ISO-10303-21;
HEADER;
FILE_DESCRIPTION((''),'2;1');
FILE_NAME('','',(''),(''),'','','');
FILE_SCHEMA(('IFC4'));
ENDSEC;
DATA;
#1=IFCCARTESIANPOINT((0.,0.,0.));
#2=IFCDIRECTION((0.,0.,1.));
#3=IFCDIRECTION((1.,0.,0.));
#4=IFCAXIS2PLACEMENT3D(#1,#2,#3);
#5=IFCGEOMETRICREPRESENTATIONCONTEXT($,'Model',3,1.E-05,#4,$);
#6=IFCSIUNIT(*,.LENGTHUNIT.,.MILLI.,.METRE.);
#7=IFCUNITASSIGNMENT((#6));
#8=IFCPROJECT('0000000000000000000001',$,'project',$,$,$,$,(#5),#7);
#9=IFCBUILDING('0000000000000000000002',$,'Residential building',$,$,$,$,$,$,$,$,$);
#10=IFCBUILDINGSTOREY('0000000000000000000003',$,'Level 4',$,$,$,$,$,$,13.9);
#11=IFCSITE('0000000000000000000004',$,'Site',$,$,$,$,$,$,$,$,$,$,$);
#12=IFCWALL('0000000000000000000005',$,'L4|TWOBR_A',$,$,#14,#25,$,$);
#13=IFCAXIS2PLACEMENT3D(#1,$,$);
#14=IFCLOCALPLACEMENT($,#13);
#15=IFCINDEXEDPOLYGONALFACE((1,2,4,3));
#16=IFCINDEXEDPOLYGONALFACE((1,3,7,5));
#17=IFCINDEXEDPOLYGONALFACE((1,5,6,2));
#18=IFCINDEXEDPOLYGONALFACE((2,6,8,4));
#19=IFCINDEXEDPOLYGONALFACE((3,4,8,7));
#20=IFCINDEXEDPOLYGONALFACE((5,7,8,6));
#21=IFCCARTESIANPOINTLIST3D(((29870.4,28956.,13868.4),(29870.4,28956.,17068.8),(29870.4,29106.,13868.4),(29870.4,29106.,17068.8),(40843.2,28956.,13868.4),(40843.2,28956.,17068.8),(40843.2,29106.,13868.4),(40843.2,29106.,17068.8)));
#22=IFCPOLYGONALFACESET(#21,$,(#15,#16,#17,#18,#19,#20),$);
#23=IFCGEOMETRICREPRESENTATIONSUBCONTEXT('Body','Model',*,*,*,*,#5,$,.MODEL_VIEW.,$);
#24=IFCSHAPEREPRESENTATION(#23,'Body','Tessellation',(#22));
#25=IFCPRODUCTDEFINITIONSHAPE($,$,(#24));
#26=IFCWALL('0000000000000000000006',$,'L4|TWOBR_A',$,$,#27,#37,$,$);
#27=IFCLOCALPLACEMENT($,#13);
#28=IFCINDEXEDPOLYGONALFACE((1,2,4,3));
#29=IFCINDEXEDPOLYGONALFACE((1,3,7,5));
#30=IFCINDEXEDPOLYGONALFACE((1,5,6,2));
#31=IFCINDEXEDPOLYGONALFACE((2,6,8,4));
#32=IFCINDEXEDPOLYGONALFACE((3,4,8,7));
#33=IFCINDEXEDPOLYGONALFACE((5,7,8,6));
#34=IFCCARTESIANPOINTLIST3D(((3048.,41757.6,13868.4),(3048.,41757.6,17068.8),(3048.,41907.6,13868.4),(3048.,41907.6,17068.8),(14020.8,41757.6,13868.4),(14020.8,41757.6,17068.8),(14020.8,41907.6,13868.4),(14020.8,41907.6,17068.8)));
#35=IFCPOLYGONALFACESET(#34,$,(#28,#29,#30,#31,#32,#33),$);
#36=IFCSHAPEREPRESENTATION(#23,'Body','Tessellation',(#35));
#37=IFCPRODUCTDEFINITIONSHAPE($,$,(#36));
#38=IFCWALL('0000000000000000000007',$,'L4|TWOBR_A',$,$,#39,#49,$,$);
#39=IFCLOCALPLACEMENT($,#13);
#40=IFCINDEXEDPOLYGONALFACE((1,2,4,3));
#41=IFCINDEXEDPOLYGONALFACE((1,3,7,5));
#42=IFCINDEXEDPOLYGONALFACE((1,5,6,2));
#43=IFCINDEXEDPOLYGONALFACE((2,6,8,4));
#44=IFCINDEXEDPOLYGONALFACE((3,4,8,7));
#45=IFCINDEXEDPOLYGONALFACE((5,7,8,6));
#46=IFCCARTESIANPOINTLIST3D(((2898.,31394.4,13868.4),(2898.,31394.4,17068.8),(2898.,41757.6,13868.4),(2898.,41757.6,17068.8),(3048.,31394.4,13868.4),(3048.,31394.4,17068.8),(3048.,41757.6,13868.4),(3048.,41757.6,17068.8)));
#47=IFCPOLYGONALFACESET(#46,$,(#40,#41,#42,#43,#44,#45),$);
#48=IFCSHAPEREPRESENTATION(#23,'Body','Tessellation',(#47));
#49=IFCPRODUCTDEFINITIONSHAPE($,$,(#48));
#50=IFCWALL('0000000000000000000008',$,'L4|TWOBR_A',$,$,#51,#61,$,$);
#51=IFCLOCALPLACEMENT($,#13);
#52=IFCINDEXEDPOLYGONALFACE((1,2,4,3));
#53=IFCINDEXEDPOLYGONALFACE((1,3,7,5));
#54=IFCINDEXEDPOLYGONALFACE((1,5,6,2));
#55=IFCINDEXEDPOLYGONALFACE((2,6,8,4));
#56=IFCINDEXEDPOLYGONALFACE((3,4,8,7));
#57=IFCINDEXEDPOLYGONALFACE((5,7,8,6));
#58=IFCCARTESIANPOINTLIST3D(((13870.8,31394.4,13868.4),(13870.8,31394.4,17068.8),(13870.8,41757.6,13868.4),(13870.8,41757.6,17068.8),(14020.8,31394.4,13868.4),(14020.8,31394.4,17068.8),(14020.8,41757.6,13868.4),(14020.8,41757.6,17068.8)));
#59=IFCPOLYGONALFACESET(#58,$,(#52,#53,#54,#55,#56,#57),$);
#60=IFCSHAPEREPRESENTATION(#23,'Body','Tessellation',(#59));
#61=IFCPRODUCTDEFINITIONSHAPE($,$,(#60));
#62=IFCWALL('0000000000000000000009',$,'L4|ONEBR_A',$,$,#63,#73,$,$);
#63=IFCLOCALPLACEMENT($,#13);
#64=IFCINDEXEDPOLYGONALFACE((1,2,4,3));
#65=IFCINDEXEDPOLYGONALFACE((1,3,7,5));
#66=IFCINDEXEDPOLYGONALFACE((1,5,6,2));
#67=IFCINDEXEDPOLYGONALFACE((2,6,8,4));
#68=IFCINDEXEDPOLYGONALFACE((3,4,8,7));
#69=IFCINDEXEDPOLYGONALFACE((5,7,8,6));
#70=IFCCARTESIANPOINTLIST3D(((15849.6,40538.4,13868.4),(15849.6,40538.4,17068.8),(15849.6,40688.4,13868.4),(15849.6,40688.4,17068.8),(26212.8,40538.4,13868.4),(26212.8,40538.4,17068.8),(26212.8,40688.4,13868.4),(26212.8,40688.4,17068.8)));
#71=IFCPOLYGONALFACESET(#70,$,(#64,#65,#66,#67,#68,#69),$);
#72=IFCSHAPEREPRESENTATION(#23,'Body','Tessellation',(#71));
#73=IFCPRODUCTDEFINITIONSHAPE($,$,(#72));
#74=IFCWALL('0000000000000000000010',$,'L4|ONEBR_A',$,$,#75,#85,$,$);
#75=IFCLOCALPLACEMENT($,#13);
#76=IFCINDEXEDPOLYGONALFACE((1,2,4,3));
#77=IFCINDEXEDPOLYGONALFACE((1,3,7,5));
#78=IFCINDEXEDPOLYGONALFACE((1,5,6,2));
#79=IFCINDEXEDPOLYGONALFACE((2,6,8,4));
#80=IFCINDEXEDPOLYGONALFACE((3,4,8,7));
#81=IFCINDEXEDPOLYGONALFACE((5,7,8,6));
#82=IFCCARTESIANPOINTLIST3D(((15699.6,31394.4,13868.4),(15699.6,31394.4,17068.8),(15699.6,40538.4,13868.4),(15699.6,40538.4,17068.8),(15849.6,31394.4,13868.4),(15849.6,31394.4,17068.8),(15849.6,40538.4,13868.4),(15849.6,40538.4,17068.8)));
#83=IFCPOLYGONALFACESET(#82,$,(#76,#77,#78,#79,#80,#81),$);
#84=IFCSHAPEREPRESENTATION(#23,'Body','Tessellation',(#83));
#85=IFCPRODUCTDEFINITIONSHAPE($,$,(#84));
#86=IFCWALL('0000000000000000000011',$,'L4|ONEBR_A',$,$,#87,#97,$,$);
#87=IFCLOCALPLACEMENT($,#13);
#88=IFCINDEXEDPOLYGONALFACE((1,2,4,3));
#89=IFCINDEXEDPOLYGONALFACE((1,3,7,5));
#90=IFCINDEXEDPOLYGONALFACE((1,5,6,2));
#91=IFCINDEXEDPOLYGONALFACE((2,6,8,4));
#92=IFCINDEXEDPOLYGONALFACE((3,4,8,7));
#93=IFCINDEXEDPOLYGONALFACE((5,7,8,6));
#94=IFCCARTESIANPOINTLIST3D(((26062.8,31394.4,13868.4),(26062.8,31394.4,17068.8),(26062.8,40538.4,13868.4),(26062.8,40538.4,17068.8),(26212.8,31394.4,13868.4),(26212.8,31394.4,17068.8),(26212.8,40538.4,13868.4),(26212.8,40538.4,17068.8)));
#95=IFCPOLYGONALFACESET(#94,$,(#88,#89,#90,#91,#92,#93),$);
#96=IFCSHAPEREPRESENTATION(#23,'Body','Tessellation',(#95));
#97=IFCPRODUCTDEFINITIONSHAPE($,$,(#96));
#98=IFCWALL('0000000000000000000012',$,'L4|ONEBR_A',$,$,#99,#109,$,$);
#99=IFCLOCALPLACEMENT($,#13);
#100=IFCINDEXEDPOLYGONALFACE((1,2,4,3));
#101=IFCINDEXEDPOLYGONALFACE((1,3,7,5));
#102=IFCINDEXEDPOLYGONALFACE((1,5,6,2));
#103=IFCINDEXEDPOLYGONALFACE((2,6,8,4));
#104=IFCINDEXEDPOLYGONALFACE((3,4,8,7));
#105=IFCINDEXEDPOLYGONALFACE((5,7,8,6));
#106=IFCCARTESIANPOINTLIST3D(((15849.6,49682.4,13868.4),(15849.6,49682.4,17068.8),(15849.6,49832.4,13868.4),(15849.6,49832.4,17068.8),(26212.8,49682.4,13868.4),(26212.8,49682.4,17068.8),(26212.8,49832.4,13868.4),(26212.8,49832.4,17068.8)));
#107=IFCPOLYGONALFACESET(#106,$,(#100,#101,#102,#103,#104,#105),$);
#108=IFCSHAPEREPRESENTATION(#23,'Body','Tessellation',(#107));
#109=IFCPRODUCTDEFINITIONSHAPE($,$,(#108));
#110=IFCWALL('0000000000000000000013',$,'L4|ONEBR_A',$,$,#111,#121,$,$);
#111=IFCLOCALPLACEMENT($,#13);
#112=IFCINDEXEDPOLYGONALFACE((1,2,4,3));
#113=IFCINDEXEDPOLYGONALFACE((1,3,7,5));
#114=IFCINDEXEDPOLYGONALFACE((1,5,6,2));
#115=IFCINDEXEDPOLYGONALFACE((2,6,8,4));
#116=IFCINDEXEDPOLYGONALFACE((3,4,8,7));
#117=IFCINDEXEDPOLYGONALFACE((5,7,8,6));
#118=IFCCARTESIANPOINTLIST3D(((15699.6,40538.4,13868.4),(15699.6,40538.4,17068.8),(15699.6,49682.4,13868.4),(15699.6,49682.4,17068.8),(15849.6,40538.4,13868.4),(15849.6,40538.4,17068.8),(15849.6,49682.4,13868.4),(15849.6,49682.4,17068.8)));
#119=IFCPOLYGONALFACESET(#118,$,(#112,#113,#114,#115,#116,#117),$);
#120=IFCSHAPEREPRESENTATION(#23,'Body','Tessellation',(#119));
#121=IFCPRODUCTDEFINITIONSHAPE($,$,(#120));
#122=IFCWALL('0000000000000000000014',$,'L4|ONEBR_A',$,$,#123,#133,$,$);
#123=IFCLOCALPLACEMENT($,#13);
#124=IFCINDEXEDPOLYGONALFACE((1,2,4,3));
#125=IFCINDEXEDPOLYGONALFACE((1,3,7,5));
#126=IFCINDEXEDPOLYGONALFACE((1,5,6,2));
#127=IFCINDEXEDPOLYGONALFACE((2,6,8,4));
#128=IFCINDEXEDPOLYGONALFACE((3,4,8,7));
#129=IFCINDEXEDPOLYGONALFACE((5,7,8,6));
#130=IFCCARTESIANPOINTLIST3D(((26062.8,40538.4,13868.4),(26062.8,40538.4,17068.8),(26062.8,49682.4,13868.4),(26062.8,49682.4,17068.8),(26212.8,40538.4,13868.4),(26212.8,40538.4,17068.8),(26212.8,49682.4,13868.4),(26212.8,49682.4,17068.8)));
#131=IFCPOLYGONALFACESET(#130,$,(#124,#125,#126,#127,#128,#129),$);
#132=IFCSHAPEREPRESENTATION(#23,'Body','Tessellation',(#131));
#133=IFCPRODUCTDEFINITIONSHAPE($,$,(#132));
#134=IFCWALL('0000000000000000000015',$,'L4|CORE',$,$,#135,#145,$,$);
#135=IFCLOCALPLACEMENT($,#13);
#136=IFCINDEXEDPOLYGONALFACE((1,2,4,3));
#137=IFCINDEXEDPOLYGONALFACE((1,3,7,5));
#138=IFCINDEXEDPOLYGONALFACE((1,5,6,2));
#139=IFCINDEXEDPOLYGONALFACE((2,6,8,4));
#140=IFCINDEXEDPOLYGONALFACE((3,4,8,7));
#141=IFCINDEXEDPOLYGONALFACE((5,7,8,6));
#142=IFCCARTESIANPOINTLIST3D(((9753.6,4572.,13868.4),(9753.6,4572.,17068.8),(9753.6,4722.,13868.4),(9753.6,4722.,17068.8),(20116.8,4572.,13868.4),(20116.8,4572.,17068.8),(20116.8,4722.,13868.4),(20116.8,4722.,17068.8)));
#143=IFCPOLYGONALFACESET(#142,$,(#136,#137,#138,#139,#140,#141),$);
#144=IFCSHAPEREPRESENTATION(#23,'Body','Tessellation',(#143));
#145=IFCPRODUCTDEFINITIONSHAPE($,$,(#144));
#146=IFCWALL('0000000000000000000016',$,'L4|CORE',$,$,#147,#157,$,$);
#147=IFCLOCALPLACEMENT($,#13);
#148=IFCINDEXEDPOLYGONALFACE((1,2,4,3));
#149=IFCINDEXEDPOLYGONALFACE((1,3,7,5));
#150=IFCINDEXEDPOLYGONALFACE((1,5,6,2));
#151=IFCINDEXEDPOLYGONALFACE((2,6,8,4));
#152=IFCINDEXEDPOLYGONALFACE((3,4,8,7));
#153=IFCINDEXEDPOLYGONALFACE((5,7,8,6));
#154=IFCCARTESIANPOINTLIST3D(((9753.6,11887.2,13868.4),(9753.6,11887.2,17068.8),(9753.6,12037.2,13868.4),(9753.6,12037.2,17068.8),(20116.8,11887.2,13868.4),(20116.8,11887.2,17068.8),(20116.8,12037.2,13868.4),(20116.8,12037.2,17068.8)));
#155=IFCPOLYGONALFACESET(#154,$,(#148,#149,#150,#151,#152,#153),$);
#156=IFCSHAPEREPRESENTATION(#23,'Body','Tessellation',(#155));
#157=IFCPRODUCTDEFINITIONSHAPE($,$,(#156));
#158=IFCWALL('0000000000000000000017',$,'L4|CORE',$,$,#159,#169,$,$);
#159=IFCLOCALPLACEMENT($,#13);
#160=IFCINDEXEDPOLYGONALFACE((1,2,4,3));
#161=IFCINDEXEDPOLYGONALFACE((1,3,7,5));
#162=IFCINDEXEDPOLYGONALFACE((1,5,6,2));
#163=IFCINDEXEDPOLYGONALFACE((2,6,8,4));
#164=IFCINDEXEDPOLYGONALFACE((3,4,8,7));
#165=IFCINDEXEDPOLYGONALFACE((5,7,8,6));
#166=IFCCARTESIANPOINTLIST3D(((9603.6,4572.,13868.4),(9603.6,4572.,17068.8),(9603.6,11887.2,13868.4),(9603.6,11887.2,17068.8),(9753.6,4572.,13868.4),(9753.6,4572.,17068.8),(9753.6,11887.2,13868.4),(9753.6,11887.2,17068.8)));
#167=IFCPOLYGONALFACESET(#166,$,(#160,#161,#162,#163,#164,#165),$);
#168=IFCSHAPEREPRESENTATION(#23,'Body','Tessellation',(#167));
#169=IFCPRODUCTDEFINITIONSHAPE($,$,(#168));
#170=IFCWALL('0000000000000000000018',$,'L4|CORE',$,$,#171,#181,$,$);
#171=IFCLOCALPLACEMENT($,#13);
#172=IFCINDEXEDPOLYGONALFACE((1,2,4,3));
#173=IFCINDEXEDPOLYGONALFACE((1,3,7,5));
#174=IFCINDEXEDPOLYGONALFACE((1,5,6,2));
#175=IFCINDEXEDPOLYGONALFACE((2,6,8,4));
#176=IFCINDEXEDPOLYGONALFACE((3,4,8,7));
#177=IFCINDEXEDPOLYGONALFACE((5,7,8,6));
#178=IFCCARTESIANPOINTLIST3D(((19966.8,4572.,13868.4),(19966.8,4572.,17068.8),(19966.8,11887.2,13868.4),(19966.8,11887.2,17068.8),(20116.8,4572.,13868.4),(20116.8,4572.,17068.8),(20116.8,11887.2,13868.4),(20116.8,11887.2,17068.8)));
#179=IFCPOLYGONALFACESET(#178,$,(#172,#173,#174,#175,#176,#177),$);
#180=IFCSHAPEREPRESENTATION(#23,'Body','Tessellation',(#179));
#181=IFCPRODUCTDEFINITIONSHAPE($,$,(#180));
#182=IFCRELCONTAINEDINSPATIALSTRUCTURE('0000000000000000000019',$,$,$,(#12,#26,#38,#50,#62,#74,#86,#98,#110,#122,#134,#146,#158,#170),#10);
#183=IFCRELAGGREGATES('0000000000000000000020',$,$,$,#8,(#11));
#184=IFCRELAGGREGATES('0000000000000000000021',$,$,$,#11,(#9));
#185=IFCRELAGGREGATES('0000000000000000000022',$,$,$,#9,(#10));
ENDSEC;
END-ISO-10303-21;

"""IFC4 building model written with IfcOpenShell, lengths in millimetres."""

from ifc_helpers import new_model, si_unit, frame, origin_with_axes, place, context, subcontext, project, spatial, indexed_curve, outline, extrude, element, save


model = new_model("IFC4")

# Units and contexts
model_context = context("Model", 3, precision=1e-05, world=origin_with_axes())
body_context = subcontext(model_context, "Body", "Model", "MODEL_VIEW")
ifc_project = project(units=[si_unit("LENGTHUNIT", "METRE", prefix="MILLI")], contexts=[model_context])

# Site, building, storey
site = spatial("IfcSite", under=ifc_project, Name="Site")
building = spatial("IfcBuilding", under=site, Name="Residential building")
storey = spatial("IfcBuildingStorey", under=building, Name="Level 4", Elevation=13.9)

# Walls
for number, where, z_axis, x_axis, name in (
    (1, (29870.4, 28956.0, 13868.4), (0.0, 0.0, 1.0), (1.0, 0.0, 0.0), "L4|TWOBR_A"),
    (2, (3048.0, 41757.6, 13868.4), (0.0, 0.0, 1.0), (1.0, 0.0, 0.0), "L4|TWOBR_A"),
):
    element("IfcWall", number, at=place(None, frame(where, z_axis=z_axis, x_axis=x_axis)), inside=storey, Name=name, context=body_context, shape_type="SweptSolid", body=[
        extrude(outline(indexed_curve([(0.0, 0.0), (0.0, 150.0), (10972.8, 150.0), (10972.8, 0.0), (0.0, 0.0)], self_intersect=False)), origin_with_axes(), (0.0, 0.0, 1.0), 3200.4),
    ])
for number, where, z_axis, x_axis, name in (
    (3, (3048.0, 31394.4, 13868.4), (0.0, 0.0, 1.0), (0.0, 1.0, 0.0), "L4|TWOBR_A"),
    (4, (14020.8, 31394.4, 13868.4), (0.0, 0.0, 1.0), (0.0, 1.0, 0.0), "L4|TWOBR_A"),
    (5, (15849.6, 40538.4, 13868.4), (0.0, 0.0, 1.0), (1.0, 0.0, 0.0), "L4|ONEBR_A"),
):
    element("IfcWall", number, at=place(None, frame(where, z_axis=z_axis, x_axis=x_axis)), inside=storey, Name=name, context=body_context, shape_type="SweptSolid", body=[
        extrude(outline(indexed_curve([(0.0, 0.0), (0.0, 150.0), (10363.2, 150.0), (10363.2, 0.0), (0.0, 0.0)], self_intersect=False)), origin_with_axes(), (0.0, 0.0, 1.0), 3200.4),
    ])
for number, where, z_axis, x_axis, name in (
    (6, (15849.6, 31394.4, 13868.4), (0.0, 0.0, 1.0), (0.0, 1.0, 0.0), "L4|ONEBR_A"),
    (7, (26212.8, 31394.4, 13868.4), (0.0, 0.0, 1.0), (0.0, 1.0, 0.0), "L4|ONEBR_A"),
):
    element("IfcWall", number, at=place(None, frame(where, z_axis=z_axis, x_axis=x_axis)), inside=storey, Name=name, context=body_context, shape_type="SweptSolid", body=[
        extrude(outline(indexed_curve([(0.0, 0.0), (0.0, 150.0), (9144.0, 150.0), (9144.0, 0.0), (0.0, 0.0)], self_intersect=False)), origin_with_axes(), (0.0, 0.0, 1.0), 3200.4),
    ])
for number, where, z_axis, x_axis, name in (
    (8, (15849.6, 49682.4, 13868.4), (0.0, 0.0, 1.0), (1.0, 0.0, 0.0), "L4|ONEBR_A"),
):
    element("IfcWall", number, at=place(None, frame(where, z_axis=z_axis, x_axis=x_axis)), inside=storey, Name=name, context=body_context, shape_type="SweptSolid", body=[
        extrude(outline(indexed_curve([(0.0, 0.0), (0.0, 150.0), (10363.2, 150.0), (10363.2, 0.0), (0.0, 0.0)], self_intersect=False)), origin_with_axes(), (0.0, 0.0, 1.0), 3200.4),
    ])
for number, where, z_axis, x_axis, name in (
    (9, (15849.6, 40538.4, 13868.4), (0.0, 0.0, 1.0), (0.0, 1.0, 0.0), "L4|ONEBR_A"),
    (10, (26212.8, 40538.4, 13868.4), (0.0, 0.0, 1.0), (0.0, 1.0, 0.0), "L4|ONEBR_A"),
):
    element("IfcWall", number, at=place(None, frame(where, z_axis=z_axis, x_axis=x_axis)), inside=storey, Name=name, context=body_context, shape_type="SweptSolid", body=[
        extrude(outline(indexed_curve([(0.0, 0.0), (0.0, 150.0), (9144.0, 150.0), (9144.0, 0.0), (0.0, 0.0)], self_intersect=False)), origin_with_axes(), (0.0, 0.0, 1.0), 3200.4),
    ])
for number, where, z_axis, x_axis, name in (
    (11, (9753.6, 4572.0, 13868.4), (0.0, 0.0, 1.0), (1.0, 0.0, 0.0), "L4|CORE"),
    (12, (9753.6, 11887.2, 13868.4), (0.0, 0.0, 1.0), (1.0, 0.0, 0.0), "L4|CORE"),
):
    element("IfcWall", number, at=place(None, frame(where, z_axis=z_axis, x_axis=x_axis)), inside=storey, Name=name, context=body_context, shape_type="SweptSolid", body=[
        extrude(outline(indexed_curve([(0.0, 0.0), (0.0, 150.0), (10363.2, 150.0), (10363.2, 0.0), (0.0, 0.0)], self_intersect=False)), origin_with_axes(), (0.0, 0.0, 1.0), 3200.4),
    ])
for number, where, z_axis, x_axis, name in (
    (13, (9753.6, 4572.0, 13868.4), (0.0, 0.0, 1.0), (0.0, 1.0, 0.0), "L4|CORE"),
    (14, (20116.8, 4572.0, 13868.4), (0.0, 0.0, 1.0), (0.0, 1.0, 0.0), "L4|CORE"),
):
    element("IfcWall", number, at=place(None, frame(where, z_axis=z_axis, x_axis=x_axis)), inside=storey, Name=name, context=body_context, shape_type="SweptSolid", body=[
        extrude(outline(indexed_curve([(0.0, 0.0), (0.0, 150.0), (7315.2, 150.0), (7315.2, 0.0), (0.0, 0.0)], self_intersect=False)), origin_with_axes(), (0.0, 0.0, 1.0), 3200.4),
    ])

save(model, "model.ifc")
